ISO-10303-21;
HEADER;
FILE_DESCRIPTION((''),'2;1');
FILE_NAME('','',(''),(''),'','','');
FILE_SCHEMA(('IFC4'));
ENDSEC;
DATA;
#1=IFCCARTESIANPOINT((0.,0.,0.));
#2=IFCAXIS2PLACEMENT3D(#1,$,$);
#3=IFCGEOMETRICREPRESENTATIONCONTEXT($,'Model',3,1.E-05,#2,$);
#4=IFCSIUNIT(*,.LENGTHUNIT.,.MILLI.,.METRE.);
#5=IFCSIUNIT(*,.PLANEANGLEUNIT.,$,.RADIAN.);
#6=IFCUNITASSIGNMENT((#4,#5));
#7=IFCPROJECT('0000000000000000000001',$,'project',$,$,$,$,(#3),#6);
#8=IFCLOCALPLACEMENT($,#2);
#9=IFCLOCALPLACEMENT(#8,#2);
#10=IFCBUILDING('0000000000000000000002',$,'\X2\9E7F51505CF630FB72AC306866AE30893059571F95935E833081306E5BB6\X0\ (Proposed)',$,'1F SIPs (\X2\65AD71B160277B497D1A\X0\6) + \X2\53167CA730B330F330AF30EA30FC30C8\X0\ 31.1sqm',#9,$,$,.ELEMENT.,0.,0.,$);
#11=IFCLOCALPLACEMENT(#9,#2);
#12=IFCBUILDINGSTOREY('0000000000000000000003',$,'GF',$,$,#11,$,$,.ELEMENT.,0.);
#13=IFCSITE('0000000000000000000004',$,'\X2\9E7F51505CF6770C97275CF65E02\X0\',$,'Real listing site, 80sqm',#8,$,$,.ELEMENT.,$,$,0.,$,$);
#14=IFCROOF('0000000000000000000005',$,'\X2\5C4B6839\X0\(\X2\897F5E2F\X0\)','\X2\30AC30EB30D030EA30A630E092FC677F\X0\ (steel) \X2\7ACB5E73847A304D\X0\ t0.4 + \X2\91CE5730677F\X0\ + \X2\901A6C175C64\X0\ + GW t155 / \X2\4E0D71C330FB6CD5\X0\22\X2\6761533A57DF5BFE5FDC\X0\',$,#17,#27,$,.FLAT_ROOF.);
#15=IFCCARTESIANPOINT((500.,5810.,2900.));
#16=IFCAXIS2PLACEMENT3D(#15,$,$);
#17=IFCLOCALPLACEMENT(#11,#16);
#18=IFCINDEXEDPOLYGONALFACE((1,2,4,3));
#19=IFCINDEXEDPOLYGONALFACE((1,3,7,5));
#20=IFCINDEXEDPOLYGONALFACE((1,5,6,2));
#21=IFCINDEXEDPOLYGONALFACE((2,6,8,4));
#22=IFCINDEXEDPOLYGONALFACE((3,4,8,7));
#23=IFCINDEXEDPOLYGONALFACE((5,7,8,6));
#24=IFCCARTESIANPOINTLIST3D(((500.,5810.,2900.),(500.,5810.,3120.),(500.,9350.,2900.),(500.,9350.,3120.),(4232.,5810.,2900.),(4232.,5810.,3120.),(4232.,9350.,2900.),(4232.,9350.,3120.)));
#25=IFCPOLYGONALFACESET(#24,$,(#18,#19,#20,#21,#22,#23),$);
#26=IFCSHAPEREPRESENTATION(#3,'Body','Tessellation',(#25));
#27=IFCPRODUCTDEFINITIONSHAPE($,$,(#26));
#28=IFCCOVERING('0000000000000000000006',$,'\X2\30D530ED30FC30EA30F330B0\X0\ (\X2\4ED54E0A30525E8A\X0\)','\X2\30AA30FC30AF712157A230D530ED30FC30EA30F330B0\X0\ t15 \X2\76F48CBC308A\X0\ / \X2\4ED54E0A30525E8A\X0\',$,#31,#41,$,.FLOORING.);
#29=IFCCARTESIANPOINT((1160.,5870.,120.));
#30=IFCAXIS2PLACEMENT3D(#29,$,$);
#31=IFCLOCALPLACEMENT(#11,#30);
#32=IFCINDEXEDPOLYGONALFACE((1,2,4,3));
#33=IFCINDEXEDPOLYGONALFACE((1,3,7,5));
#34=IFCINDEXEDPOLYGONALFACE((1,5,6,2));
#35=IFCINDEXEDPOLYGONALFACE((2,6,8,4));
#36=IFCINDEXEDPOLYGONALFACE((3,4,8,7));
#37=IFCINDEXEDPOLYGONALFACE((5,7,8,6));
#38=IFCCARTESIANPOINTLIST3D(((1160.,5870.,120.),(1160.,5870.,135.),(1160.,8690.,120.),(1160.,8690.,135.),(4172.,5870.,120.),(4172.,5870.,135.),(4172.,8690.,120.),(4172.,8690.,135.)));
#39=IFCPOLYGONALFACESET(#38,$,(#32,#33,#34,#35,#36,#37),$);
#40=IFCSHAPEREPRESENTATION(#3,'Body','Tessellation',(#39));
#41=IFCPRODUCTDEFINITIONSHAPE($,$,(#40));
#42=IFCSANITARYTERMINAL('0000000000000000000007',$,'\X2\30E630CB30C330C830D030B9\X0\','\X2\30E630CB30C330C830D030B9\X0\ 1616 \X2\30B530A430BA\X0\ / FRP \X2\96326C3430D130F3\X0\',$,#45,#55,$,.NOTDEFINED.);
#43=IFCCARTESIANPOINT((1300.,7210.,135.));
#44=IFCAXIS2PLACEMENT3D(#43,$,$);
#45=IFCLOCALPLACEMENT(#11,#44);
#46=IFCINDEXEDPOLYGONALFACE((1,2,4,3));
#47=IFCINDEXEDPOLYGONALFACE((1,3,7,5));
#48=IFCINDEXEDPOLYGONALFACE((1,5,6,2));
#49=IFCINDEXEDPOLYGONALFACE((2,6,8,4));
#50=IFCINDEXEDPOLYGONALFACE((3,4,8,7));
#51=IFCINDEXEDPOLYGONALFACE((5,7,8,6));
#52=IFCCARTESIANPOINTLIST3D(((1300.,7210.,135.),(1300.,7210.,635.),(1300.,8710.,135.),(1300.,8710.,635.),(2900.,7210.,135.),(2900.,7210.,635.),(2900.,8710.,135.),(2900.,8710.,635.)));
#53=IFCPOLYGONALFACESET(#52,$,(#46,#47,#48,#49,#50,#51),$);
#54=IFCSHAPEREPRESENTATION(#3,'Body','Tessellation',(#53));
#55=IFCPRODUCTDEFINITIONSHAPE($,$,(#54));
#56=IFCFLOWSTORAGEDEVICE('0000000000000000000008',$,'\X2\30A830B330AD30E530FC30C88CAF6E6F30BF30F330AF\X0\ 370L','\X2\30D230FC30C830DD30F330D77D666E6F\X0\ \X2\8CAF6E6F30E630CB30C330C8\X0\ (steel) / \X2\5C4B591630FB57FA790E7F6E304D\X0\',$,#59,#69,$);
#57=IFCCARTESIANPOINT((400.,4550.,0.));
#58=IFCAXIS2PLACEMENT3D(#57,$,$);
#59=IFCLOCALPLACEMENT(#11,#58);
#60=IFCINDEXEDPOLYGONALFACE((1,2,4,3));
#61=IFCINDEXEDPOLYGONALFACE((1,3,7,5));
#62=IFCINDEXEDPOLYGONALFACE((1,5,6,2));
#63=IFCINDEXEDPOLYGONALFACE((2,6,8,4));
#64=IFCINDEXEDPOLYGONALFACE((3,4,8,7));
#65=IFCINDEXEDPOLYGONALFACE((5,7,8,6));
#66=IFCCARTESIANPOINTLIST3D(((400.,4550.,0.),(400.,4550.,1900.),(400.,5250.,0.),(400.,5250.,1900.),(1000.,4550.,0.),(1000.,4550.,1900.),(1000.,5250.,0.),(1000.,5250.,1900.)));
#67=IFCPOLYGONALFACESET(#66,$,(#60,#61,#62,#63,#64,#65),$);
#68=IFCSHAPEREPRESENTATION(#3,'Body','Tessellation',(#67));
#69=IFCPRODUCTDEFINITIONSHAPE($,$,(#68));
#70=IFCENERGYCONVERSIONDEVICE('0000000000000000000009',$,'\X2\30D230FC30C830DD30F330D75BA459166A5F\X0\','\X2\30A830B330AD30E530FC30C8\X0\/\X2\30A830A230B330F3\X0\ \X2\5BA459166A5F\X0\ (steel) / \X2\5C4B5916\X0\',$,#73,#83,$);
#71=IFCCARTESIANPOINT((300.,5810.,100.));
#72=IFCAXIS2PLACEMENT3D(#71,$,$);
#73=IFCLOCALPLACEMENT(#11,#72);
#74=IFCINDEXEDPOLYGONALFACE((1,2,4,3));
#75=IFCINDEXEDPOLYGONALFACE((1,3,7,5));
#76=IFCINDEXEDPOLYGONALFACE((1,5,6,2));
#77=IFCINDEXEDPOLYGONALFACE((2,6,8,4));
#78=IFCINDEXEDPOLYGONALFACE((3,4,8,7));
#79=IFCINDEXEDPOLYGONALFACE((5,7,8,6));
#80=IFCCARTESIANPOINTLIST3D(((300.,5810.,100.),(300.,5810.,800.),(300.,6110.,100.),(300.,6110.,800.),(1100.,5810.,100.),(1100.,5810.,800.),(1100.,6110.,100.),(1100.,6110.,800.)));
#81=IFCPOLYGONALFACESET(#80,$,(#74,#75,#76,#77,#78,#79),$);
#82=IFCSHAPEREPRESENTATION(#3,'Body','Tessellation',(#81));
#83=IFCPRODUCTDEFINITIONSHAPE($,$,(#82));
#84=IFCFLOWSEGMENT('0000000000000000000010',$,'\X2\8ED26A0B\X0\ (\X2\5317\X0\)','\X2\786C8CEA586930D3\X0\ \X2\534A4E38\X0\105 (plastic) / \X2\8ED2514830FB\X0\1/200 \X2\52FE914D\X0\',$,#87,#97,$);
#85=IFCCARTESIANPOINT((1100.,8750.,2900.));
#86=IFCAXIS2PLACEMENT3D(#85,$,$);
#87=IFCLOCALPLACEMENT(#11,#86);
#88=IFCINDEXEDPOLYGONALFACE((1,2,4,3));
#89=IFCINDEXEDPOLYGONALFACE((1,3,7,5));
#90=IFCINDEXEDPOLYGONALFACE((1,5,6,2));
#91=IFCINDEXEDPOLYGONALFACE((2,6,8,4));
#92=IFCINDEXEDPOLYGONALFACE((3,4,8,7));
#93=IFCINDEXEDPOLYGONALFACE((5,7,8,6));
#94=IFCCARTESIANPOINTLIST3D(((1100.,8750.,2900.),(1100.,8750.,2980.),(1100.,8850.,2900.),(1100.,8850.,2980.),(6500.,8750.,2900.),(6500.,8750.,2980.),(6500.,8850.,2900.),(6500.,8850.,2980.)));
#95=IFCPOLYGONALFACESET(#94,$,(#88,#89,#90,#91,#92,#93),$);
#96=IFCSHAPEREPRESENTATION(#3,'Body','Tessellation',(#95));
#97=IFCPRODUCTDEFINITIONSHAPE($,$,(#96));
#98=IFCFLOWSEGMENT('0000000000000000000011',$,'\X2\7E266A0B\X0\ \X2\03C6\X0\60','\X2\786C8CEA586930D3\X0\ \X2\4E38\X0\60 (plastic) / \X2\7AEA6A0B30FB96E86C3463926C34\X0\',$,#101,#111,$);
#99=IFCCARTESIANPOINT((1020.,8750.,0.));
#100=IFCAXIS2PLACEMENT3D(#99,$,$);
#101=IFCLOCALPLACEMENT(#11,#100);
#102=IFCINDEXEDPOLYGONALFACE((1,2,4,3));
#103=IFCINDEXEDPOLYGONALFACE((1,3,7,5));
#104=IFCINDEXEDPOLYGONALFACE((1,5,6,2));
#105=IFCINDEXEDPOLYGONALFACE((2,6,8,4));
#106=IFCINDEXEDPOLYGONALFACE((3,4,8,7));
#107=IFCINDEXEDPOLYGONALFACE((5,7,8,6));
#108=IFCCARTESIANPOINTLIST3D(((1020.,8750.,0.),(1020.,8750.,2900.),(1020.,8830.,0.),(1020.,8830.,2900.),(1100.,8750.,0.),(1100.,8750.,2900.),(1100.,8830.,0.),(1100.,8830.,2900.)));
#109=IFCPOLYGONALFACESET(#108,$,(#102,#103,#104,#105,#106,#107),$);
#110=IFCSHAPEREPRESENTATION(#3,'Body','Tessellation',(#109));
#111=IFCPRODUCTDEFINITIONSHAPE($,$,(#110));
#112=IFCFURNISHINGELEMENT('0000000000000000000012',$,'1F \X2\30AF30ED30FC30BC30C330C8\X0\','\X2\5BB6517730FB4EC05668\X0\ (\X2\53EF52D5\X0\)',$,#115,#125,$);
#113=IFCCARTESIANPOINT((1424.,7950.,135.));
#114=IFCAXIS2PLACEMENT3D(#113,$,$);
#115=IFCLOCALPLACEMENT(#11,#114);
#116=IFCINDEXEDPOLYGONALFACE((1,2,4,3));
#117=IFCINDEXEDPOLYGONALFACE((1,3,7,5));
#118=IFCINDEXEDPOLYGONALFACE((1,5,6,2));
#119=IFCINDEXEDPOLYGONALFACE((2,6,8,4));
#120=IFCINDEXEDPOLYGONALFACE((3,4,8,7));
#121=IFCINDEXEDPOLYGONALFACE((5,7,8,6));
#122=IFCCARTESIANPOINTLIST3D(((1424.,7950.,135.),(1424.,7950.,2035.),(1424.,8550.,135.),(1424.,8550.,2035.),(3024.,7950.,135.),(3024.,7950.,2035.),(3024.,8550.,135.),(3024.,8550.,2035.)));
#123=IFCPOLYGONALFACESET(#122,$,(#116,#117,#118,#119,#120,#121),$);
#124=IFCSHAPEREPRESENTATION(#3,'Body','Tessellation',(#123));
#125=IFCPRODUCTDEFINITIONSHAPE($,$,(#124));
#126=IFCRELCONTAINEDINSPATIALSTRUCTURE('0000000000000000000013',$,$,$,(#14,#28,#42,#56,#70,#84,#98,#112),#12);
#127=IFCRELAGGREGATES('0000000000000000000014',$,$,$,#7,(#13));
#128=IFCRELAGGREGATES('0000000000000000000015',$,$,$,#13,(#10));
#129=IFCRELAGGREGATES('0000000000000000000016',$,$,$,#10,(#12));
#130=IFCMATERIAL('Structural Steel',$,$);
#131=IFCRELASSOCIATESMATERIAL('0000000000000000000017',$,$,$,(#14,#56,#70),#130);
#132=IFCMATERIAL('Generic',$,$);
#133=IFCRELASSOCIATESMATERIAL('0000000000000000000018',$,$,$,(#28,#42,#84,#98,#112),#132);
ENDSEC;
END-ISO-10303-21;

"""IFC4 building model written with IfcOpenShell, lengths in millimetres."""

from ifc_helpers import new_model, si_unit, frame, frame_2d, origin, place, context, project, spatial, rectangle, extrude, material, element, save


model = new_model("IFC4")

# Units and contexts
model_context = context("Model", 3, precision=1e-05, world=origin())
ifc_project = project(units=[si_unit("LENGTHUNIT", "METRE", prefix="MILLI"), si_unit("PLANEANGLEUNIT", "RADIAN")], contexts=[model_context])

# Site, building, storey
site_placement = place(None, origin())
site = spatial("IfcSite", under=ifc_project, at=site_placement, Name="鹿児島県霧島市", ObjectType="Real listing site, 80sqm", CompositionType="ELEMENT", RefElevation=0.0)
building_placement = place(site_placement, origin())
building = spatial("IfcBuilding", under=site, at=building_placement, Name="鹿児島・犬と暮らす土間広めの家 (Proposed)", ObjectType="1F SIPs (断熱性等級6) + 化粧コンクリート 31.1sqm", CompositionType="ELEMENT", ElevationOfRefHeight=0.0, ElevationOfTerrain=0.0)
storey_placement = place(building_placement, origin())
storey = spatial("IfcBuildingStorey", under=building, at=storey_placement, Name="GF", CompositionType="ELEMENT", Elevation=0.0)

# Roof
ifc_material_1 = material(Name="Structural Steel")
roof_placement = place(storey_placement, frame((500.0, 5810.0, 2900.0)))
element("IfcRoof", 1, at=roof_placement, inside=storey, material=ifc_material_1, Name="屋根(西帯)", Description="ガルバリウム鋼板 (steel) 立平葺き t0.4 + 野地板 + 通気層 + GW t155 / 不燃・法22条区域対応", PredefinedType="FLAT_ROOF", context=model_context, shape_type="SweptSolid", body=[
    extrude(rectangle(XDim=3732.0, YDim=3540.0, at=frame_2d((1866.0, 1770.0))), frame((500.0, 5810.0, 2900.0)), (0.0, 0.0, 1.0), 220.0),
])

# Covering
ifc_material_2 = material(Name="Generic")
covering_placement = place(storey_placement, frame((1160.0, 5870.0, 120.0)))
element("IfcCovering", 2, at=covering_placement, inside=storey, material=ifc_material_2, Name="フローリング (仕上げ床)", Description="オーク無垢フローリング t15 直貼り / 仕上げ床", PredefinedType="FLOORING", context=model_context, shape_type="SweptSolid", body=[
    extrude(rectangle(XDim=3012.0, YDim=2820.0, at=frame_2d((1506.0, 1410.0))), frame((1160.0, 5870.0, 120.0)), (0.0, 0.0, 1.0), 15.0),
])

# Sanitary terminal
sanitary_terminal_placement = place(storey_placement, frame((1300.0, 7210.0, 135.0)))
element("IfcSanitaryTerminal", 3, at=sanitary_terminal_placement, inside=storey, material=ifc_material_2, Name="ユニットバス", Description="ユニットバス 1616 サイズ / FRP 防水パン", PredefinedType="NOTDEFINED", context=model_context, shape_type="SweptSolid", body=[
    extrude(rectangle(XDim=1600.0, YDim=1500.0, at=frame_2d((800.0, 750.0))), frame((1300.0, 7210.0, 135.0)), (0.0, 0.0, 1.0), 500.0),
])

# Flow storage device
flow_storage_device_placement = place(storey_placement, frame((400.0, 4550.0, 0.0)))
element("IfcFlowStorageDevice", 4, at=flow_storage_device_placement, inside=storey, material=ifc_material_1, Name="エコキュート貯湯タンク 370L", Description="ヒートポンプ給湯 貯湯ユニット (steel) / 屋外・基礎置き", context=model_context, shape_type="SweptSolid", body=[
    extrude(rectangle(XDim=600.0, YDim=700.0, at=frame_2d((300.0, 350.0))), frame((400.0, 4550.0, 0.0)), (0.0, 0.0, 1.0), 1900.0),
])

# Energy conversion device
energy_conversion_device_placement = place(storey_placement, frame((300.0, 5810.0, 100.0)))
element("IfcEnergyConversionDevice", 5, at=energy_conversion_device_placement, inside=storey, material=ifc_material_1, Name="ヒートポンプ室外機", Description="エコキュート/エアコン 室外機 (steel) / 屋外", context=model_context, shape_type="SweptSolid", body=[
    extrude(rectangle(XDim=800.0, YDim=300.0, at=frame_2d((400.0, 150.0))), frame((300.0, 5810.0, 100.0)), (0.0, 0.0, 1.0), 700.0),
])

# Flow segments
flow_segment_1_placement = place(storey_placement, frame((1100.0, 8750.0, 2900.0)))
element("IfcFlowSegment", 6, at=flow_segment_1_placement, inside=storey, material=ifc_material_2, Name="軒樋 (北)", Description="硬質塩ビ 半丸105 (plastic) / 軒先・1/200 勾配", context=model_context, shape_type="SweptSolid", body=[
    extrude(rectangle(XDim=5400.0, YDim=100.0, at=frame_2d((2700.0, 50.0))), frame((1100.0, 8750.0, 2900.0)), (0.0, 0.0, 1.0), 80.0),
])
flow_segment_2_placement = place(storey_placement, frame((1020.0, 8750.0, 0.0)))
element("IfcFlowSegment", 7, at=flow_segment_2_placement, inside=storey, material=ifc_material_2, Name="縦樋 φ60", Description="硬質塩ビ 丸60 (plastic) / 竪樋・雨水排水", context=model_context, shape_type="SweptSolid", body=[
    extrude(rectangle(XDim=80.0, YDim=80.0, at=frame_2d((40.0, 40.0))), frame((1020.0, 8750.0, 0.0)), (0.0, 0.0, 1.0), 2900.0),
])

# Furnishing element
furnishing_placement = place(storey_placement, frame((1424.0, 7950.0, 135.0)))
element("IfcFurnishingElement", 8, at=furnishing_placement, inside=storey, material=ifc_material_2, Name="1F クローゼット", Description="家具・什器 (可動)", context=model_context, shape_type="SweptSolid", body=[
    extrude(rectangle(XDim=1600.0, YDim=600.0, at=frame_2d((800.0, 300.0))), frame((1424.0, 7950.0, 135.0)), (0.0, 0.0, 1.0), 1900.0),
])

save(model, "model.ifc")
